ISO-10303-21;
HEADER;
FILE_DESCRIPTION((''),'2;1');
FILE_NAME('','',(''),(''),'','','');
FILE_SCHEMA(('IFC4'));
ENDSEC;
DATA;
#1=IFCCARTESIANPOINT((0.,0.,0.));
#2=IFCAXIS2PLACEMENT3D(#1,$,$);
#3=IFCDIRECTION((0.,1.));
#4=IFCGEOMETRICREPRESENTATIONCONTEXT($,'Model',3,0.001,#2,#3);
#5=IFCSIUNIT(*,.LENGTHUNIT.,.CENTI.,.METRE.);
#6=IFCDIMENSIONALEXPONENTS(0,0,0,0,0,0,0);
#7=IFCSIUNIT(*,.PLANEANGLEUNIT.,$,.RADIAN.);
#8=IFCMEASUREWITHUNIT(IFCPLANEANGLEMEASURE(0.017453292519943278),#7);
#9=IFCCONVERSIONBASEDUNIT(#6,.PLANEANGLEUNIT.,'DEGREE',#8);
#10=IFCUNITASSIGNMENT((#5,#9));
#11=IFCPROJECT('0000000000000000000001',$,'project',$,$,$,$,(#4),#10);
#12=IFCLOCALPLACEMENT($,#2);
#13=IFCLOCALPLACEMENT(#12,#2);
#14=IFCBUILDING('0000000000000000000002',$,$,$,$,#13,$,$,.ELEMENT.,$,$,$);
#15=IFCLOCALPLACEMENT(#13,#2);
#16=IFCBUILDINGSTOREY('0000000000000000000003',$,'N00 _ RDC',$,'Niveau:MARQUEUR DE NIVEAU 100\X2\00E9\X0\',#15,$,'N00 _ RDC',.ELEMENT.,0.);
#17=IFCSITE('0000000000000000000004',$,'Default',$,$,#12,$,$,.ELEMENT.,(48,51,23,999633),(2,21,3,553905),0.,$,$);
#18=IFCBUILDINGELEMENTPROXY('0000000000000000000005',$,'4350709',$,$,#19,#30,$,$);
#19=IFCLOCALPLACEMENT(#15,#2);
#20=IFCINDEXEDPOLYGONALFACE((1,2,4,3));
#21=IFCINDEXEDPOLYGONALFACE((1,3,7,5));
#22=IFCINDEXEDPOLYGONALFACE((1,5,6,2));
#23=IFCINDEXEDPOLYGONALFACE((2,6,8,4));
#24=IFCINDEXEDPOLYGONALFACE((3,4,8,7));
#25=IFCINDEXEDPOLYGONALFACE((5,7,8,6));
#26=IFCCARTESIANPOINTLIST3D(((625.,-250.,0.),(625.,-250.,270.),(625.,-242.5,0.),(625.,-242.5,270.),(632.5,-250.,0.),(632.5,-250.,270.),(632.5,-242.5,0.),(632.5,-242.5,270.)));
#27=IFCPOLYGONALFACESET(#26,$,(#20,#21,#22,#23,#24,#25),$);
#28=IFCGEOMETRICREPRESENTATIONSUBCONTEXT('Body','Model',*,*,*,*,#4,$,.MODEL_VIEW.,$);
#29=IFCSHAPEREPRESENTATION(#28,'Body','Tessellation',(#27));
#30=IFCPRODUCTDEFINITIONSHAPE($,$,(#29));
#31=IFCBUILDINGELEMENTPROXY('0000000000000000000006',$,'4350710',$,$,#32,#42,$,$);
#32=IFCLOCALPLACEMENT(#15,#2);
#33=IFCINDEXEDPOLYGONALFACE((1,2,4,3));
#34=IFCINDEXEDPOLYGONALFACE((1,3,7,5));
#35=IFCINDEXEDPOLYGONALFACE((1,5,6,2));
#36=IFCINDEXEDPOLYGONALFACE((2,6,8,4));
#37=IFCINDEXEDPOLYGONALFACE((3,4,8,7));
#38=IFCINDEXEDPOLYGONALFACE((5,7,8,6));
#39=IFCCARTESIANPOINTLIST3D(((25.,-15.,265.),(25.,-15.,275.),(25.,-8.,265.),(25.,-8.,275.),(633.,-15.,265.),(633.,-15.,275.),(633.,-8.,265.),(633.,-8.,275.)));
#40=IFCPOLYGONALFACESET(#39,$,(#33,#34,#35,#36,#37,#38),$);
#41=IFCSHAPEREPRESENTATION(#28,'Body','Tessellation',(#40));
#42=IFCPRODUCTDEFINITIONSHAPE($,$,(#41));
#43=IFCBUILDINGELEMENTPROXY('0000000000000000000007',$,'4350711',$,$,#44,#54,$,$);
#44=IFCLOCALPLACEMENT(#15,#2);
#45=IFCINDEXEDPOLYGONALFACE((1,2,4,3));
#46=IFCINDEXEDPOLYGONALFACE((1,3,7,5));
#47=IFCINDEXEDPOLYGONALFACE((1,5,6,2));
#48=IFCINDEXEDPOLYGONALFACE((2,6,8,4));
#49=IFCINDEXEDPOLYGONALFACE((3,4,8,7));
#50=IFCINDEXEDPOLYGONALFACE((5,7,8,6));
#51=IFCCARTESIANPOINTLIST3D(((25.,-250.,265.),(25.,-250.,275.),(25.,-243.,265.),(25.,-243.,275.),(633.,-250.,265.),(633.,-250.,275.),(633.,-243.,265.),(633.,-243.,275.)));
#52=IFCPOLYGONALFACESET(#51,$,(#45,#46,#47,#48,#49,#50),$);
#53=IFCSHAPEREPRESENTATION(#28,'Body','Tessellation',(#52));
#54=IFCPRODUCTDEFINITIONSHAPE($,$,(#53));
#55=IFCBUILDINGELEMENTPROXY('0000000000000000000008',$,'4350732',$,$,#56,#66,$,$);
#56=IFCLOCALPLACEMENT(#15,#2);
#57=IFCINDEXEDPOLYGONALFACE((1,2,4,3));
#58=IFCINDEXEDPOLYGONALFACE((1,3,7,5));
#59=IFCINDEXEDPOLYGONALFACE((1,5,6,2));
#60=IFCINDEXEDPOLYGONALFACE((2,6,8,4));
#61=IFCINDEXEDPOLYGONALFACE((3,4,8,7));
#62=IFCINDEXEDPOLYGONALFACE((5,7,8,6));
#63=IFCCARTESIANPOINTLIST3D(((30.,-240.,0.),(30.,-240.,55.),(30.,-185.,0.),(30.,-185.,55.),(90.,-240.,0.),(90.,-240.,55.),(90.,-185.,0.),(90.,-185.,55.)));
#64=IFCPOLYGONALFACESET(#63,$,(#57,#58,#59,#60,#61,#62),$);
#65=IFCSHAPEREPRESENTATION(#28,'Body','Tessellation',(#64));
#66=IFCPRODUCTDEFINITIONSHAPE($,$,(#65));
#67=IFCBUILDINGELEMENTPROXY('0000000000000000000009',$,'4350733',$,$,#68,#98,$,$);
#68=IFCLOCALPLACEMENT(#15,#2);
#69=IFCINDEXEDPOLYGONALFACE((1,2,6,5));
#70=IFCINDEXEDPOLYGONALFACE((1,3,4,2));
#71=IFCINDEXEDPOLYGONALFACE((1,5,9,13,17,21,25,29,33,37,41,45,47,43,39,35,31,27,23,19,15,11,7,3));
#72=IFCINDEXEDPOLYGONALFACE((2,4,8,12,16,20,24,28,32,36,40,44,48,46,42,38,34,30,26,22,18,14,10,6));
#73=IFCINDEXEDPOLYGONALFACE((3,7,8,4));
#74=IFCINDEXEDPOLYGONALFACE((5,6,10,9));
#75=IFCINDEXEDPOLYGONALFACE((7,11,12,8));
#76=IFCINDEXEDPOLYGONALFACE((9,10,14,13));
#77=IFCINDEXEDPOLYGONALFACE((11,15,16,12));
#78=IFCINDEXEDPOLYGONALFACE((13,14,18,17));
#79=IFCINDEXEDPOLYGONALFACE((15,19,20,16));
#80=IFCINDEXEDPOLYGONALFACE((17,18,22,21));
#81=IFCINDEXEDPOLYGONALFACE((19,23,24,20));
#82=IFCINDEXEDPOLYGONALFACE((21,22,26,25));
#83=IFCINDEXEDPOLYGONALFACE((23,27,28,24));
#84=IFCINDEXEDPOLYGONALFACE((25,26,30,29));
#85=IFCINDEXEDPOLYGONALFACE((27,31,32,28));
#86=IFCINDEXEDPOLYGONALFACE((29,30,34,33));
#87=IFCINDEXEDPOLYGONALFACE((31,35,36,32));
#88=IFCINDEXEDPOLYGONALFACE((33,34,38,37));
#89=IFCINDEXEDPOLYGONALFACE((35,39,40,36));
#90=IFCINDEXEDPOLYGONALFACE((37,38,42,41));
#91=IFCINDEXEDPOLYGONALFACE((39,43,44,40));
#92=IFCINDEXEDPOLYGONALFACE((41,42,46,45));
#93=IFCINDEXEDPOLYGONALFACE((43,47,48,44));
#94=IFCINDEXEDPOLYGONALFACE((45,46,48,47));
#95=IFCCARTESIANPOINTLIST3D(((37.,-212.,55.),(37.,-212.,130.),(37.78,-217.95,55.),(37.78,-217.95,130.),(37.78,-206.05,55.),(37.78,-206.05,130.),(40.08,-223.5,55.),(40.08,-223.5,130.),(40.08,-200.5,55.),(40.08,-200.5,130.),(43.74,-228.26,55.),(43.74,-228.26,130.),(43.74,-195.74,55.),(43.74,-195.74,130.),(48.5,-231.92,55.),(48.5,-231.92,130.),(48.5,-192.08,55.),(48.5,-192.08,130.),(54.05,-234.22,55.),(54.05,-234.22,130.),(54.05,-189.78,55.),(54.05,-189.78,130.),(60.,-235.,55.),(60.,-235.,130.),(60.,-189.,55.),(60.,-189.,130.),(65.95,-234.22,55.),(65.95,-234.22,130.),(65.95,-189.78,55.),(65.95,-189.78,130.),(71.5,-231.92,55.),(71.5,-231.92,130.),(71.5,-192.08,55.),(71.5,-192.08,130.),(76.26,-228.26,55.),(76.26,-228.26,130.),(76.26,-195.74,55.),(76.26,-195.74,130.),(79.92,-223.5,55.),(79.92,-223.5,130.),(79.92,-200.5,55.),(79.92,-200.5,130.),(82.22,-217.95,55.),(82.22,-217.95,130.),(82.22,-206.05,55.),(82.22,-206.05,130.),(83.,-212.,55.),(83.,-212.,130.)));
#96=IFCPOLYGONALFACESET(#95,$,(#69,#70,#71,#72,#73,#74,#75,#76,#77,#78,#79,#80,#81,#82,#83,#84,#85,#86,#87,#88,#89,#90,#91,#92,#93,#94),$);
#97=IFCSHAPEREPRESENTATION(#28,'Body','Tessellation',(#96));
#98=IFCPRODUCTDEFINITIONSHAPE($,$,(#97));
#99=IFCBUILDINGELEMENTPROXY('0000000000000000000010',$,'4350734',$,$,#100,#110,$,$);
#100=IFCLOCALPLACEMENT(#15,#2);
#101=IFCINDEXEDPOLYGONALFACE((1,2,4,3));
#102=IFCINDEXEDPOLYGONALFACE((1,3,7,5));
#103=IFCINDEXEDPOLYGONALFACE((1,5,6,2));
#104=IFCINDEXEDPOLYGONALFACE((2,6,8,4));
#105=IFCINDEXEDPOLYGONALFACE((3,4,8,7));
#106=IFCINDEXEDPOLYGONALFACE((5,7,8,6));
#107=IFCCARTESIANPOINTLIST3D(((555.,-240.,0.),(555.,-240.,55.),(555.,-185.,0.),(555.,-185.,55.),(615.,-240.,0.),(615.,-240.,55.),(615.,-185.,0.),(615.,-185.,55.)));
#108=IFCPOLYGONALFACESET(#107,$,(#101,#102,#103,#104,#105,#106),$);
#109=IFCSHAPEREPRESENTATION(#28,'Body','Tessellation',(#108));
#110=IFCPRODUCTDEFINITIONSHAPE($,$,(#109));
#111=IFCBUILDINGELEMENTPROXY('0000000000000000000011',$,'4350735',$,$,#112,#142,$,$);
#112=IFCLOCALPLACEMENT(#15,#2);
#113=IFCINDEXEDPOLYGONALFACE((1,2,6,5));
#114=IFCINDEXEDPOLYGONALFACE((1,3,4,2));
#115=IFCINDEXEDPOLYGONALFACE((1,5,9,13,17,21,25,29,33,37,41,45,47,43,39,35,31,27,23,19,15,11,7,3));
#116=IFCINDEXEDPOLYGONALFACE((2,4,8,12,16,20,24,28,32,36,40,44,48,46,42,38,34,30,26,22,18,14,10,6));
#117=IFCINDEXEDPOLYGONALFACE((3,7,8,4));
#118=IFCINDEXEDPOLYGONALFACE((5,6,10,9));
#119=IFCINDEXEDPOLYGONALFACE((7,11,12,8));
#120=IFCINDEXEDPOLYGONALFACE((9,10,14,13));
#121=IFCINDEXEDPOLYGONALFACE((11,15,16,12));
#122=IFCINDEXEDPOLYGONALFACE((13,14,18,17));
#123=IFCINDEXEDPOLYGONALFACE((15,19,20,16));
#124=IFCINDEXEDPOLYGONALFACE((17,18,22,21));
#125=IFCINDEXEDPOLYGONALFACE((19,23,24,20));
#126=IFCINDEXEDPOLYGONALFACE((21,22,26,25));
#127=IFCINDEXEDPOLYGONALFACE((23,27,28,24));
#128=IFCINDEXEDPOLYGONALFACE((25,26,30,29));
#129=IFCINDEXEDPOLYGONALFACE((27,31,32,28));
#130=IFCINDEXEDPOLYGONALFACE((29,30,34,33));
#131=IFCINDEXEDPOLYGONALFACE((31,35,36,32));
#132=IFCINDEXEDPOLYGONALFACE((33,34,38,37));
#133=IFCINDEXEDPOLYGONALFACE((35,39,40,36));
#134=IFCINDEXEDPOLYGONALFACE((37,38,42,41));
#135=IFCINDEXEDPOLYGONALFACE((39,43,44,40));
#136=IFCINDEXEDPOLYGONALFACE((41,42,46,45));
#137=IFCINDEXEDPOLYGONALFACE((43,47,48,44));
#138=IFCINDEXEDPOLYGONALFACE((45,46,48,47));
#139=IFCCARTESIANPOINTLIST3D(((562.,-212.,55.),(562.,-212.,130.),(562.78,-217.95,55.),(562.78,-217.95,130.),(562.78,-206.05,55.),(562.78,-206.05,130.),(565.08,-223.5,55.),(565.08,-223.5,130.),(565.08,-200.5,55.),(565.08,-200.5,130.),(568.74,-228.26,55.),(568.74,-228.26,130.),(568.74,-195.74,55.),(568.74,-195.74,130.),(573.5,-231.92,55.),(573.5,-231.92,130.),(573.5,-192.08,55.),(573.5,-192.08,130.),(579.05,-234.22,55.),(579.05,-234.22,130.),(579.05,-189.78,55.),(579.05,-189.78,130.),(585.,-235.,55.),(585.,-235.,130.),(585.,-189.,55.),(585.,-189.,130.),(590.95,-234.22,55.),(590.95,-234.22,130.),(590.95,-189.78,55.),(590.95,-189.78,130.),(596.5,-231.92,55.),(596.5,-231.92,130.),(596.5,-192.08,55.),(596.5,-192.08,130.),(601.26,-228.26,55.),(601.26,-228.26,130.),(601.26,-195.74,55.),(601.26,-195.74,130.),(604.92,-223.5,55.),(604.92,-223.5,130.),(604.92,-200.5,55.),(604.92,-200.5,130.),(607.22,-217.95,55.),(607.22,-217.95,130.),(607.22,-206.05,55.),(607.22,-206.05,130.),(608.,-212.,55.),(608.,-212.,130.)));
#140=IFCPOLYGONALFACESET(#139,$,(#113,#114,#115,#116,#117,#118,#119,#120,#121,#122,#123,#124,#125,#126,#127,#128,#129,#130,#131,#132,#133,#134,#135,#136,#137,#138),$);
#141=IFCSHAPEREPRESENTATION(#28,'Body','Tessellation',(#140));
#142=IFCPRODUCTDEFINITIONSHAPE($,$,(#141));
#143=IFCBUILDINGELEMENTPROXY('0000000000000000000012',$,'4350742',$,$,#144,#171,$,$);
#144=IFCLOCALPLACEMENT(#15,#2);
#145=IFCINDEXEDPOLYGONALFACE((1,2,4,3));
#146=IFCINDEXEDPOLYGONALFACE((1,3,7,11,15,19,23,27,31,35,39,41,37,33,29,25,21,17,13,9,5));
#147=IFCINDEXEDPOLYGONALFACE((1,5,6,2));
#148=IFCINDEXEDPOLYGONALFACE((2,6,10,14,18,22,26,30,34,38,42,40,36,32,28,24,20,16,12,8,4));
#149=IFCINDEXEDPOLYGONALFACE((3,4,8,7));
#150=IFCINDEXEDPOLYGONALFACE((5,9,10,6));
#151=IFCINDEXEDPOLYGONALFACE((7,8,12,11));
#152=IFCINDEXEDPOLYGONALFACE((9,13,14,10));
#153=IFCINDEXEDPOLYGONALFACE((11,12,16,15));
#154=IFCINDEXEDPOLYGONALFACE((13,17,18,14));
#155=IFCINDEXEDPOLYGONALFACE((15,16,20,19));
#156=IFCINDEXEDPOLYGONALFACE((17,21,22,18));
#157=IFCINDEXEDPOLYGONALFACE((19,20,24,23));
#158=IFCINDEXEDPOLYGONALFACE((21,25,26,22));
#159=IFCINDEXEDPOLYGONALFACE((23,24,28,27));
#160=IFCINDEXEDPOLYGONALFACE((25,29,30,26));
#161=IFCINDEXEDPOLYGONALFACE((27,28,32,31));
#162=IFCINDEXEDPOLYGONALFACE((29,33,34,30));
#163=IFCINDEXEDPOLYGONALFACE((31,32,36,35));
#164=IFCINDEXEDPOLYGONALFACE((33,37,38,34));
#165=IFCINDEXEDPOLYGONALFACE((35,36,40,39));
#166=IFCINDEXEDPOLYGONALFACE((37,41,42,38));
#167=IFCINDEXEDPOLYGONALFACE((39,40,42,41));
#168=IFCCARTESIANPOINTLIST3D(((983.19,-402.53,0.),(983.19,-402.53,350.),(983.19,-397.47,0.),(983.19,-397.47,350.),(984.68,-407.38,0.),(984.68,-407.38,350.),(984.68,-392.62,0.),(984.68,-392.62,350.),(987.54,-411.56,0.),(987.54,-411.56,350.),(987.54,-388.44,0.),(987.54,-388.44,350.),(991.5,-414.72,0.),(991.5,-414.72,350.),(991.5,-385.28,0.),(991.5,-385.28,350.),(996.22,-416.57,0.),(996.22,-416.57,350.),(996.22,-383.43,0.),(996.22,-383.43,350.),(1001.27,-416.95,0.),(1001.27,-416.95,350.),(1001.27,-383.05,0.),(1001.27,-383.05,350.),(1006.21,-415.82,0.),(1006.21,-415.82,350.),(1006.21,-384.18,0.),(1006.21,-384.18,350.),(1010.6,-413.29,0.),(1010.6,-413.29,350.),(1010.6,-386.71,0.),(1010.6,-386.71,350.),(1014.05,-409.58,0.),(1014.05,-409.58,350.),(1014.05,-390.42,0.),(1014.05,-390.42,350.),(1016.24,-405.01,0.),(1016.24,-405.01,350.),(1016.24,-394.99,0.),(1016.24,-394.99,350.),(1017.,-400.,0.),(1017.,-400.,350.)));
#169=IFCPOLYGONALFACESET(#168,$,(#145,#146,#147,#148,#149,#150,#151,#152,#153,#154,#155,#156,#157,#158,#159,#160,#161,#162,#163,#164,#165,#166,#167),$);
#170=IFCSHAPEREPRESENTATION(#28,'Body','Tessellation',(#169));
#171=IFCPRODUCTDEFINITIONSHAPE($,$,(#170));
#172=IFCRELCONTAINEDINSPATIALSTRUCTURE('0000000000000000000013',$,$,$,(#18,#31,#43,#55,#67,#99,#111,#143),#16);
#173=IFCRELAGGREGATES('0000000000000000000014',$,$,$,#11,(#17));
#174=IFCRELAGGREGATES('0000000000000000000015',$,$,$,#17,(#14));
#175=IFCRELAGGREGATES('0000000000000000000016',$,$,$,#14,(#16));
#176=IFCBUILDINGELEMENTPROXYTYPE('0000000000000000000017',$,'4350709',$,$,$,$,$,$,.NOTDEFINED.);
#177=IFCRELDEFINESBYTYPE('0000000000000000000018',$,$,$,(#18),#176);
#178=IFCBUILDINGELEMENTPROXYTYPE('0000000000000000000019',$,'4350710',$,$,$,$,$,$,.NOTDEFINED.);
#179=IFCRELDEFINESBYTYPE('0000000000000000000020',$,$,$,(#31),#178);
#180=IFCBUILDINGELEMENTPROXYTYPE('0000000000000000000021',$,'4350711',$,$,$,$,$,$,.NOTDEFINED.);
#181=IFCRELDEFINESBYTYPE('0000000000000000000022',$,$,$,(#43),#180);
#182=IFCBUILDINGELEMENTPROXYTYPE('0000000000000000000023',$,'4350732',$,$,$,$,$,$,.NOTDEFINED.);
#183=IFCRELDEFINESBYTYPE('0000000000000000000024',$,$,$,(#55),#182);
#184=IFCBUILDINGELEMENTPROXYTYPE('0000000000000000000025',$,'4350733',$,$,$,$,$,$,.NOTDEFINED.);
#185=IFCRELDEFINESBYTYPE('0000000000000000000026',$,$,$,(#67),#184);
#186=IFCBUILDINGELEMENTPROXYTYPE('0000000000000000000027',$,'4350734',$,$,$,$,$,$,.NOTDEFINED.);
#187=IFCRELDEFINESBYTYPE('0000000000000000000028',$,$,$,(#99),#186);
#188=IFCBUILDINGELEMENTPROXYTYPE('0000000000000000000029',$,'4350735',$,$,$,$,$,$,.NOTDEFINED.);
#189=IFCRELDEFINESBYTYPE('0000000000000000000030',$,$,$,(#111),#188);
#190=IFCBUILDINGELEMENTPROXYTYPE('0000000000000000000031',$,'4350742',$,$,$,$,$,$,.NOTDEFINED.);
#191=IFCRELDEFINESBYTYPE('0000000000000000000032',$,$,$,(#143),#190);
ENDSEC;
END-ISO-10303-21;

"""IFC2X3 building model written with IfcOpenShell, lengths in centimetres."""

from ifc_helpers import new_model, entity, si_unit, converted_unit, direction, frame, frame_2d, origin, origin_2d_with_axis, place, context, subcontext, project, spatial, rectangle, circle, extrude, type_object, element, save


model = new_model("IFC2X3")

# Units and contexts
model_context = context("Model", 3, precision=0.001, world=origin(), true_north=direction((0.0, 1.0)))
body_context = subcontext(model_context, "Body", "Model", "MODEL_VIEW")
ifc_project = project(units=[si_unit("LENGTHUNIT", "METRE", prefix="CENTI"), converted_unit("PLANEANGLEUNIT", "DEGREE", entity("IfcPlaneAngleMeasure", 0.017453292519943278), si_unit("PLANEANGLEUNIT", "RADIAN"), dimensions=[0, 0, 0, 0, 0, 0, 0])], contexts=[model_context])

# Site, building, storey
site_placement = place(None, origin())
site = spatial("IfcSite", under=ifc_project, at=site_placement, Name="Default", CompositionType="ELEMENT", RefLatitude=(48, 51, 23, 999633), RefLongitude=(2, 21, 3, 553905), RefElevation=0.0)
building_placement = place(site_placement, origin())
building = spatial("IfcBuilding", under=site, at=building_placement, CompositionType="ELEMENT")
storey_placement = place(building_placement, origin())
storey = spatial("IfcBuildingStorey", under=building, at=storey_placement, Name="N00 _ RDC", ObjectType="Niveau:MARQUEUR DE NIVEAU 100é", LongName="N00 _ RDC", CompositionType="ELEMENT", Elevation=0.0)

# Building element proxies
building_element_proxy_type_1 = type_object("IfcBuildingElementProxyType", Name="4350709", PredefinedType="NOTDEFINED")
proxy_1_placement = place(storey_placement, origin())
element("IfcBuildingElementProxy", 1, at=proxy_1_placement, inside=storey, type_object=building_element_proxy_type_1, Name="4350709", context=body_context, shape_type="SweptSolid", body=[
    extrude(rectangle(XDim=7.5, YDim=7.5, at=origin_2d_with_axis()), frame((628.75, -246.25, 0.0)), (0.0, 0.0, 1.0), 270.0),
])
building_element_proxy_type_2 = type_object("IfcBuildingElementProxyType", Name="4350710", PredefinedType="NOTDEFINED")
proxy_2_placement = place(storey_placement, origin())
element("IfcBuildingElementProxy", 2, at=proxy_2_placement, inside=storey, type_object=building_element_proxy_type_2, Name="4350710", context=body_context, shape_type="SweptSolid", body=[
    extrude(rectangle(XDim=608.0, YDim=7.0, at=frame_2d((0.0, 0.0), x_axis=(1.0, 0.0))), frame((329.0, -11.5, 265.0)), (0.0, 0.0, 1.0), 10.0),
])
building_element_proxy_type_3 = type_object("IfcBuildingElementProxyType", Name="4350711", PredefinedType="NOTDEFINED")
proxy_3_placement = place(storey_placement, origin())
element("IfcBuildingElementProxy", 3, at=proxy_3_placement, inside=storey, type_object=building_element_proxy_type_3, Name="4350711", context=body_context, shape_type="SweptSolid", body=[
    extrude(rectangle(XDim=608.0, YDim=7.0, at=frame_2d((0.0, 0.0), x_axis=(1.0, 0.0))), frame((329.0, -246.5, 265.0)), (0.0, 0.0, 1.0), 10.0),
])
building_element_proxy_type_4 = type_object("IfcBuildingElementProxyType", Name="4350732", PredefinedType="NOTDEFINED")
proxy_4_placement = place(storey_placement, origin())
element("IfcBuildingElementProxy", 4, at=proxy_4_placement, inside=storey, type_object=building_element_proxy_type_4, Name="4350732", context=body_context, shape_type="SweptSolid", body=[
    extrude(rectangle(XDim=60.0, YDim=55.0, at=frame_2d((0.0, 0.0), x_axis=(1.0, 0.0))), frame((60.0, -212.5, 0.0)), (0.0, 0.0, 1.0), 55.0),
])
building_element_proxy_type_5 = type_object("IfcBuildingElementProxyType", Name="4350733", PredefinedType="NOTDEFINED")
proxy_5_placement = place(storey_placement, origin())
element("IfcBuildingElementProxy", 5, at=proxy_5_placement, inside=storey, type_object=building_element_proxy_type_5, Name="4350733", context=body_context, shape_type="SweptSolid", body=[
    extrude(circle(Radius=23.0, at=origin_2d_with_axis()), frame((60.0, -212.0, 55.0)), (0.0, 0.0, 1.0), 75.0),
])
building_element_proxy_type_6 = type_object("IfcBuildingElementProxyType", Name="4350734", PredefinedType="NOTDEFINED")
proxy_6_placement = place(storey_placement, origin())
element("IfcBuildingElementProxy", 6, at=proxy_6_placement, inside=storey, type_object=building_element_proxy_type_6, Name="4350734", context=body_context, shape_type="SweptSolid", body=[
    extrude(rectangle(XDim=60.0, YDim=55.0, at=origin_2d_with_axis()), frame((585.0, -212.5, 0.0)), (0.0, 0.0, 1.0), 55.0),
])
building_element_proxy_type_7 = type_object("IfcBuildingElementProxyType", Name="4350735", PredefinedType="NOTDEFINED")
proxy_7_placement = place(storey_placement, origin())
element("IfcBuildingElementProxy", 7, at=proxy_7_placement, inside=storey, type_object=building_element_proxy_type_7, Name="4350735", context=body_context, shape_type="SweptSolid", body=[
    extrude(circle(Radius=23.0, at=origin_2d_with_axis()), frame((585.0, -212.0, 55.0)), (0.0, 0.0, 1.0), 75.0),
])
building_element_proxy_type_8 = type_object("IfcBuildingElementProxyType", Name="4350742", PredefinedType="NOTDEFINED")
proxy_8_placement = place(storey_placement, origin())
element("IfcBuildingElementProxy", 8, at=proxy_8_placement, inside=storey, type_object=building_element_proxy_type_8, Name="4350742", context=body_context, shape_type="SweptSolid", body=[
    extrude(circle(Radius=17.0, at=origin_2d_with_axis()), frame((1000.0, -400.0, 0.0)), (0.0, 0.0, 1.0), 350.0),
])

save(model, "model.ifc")
